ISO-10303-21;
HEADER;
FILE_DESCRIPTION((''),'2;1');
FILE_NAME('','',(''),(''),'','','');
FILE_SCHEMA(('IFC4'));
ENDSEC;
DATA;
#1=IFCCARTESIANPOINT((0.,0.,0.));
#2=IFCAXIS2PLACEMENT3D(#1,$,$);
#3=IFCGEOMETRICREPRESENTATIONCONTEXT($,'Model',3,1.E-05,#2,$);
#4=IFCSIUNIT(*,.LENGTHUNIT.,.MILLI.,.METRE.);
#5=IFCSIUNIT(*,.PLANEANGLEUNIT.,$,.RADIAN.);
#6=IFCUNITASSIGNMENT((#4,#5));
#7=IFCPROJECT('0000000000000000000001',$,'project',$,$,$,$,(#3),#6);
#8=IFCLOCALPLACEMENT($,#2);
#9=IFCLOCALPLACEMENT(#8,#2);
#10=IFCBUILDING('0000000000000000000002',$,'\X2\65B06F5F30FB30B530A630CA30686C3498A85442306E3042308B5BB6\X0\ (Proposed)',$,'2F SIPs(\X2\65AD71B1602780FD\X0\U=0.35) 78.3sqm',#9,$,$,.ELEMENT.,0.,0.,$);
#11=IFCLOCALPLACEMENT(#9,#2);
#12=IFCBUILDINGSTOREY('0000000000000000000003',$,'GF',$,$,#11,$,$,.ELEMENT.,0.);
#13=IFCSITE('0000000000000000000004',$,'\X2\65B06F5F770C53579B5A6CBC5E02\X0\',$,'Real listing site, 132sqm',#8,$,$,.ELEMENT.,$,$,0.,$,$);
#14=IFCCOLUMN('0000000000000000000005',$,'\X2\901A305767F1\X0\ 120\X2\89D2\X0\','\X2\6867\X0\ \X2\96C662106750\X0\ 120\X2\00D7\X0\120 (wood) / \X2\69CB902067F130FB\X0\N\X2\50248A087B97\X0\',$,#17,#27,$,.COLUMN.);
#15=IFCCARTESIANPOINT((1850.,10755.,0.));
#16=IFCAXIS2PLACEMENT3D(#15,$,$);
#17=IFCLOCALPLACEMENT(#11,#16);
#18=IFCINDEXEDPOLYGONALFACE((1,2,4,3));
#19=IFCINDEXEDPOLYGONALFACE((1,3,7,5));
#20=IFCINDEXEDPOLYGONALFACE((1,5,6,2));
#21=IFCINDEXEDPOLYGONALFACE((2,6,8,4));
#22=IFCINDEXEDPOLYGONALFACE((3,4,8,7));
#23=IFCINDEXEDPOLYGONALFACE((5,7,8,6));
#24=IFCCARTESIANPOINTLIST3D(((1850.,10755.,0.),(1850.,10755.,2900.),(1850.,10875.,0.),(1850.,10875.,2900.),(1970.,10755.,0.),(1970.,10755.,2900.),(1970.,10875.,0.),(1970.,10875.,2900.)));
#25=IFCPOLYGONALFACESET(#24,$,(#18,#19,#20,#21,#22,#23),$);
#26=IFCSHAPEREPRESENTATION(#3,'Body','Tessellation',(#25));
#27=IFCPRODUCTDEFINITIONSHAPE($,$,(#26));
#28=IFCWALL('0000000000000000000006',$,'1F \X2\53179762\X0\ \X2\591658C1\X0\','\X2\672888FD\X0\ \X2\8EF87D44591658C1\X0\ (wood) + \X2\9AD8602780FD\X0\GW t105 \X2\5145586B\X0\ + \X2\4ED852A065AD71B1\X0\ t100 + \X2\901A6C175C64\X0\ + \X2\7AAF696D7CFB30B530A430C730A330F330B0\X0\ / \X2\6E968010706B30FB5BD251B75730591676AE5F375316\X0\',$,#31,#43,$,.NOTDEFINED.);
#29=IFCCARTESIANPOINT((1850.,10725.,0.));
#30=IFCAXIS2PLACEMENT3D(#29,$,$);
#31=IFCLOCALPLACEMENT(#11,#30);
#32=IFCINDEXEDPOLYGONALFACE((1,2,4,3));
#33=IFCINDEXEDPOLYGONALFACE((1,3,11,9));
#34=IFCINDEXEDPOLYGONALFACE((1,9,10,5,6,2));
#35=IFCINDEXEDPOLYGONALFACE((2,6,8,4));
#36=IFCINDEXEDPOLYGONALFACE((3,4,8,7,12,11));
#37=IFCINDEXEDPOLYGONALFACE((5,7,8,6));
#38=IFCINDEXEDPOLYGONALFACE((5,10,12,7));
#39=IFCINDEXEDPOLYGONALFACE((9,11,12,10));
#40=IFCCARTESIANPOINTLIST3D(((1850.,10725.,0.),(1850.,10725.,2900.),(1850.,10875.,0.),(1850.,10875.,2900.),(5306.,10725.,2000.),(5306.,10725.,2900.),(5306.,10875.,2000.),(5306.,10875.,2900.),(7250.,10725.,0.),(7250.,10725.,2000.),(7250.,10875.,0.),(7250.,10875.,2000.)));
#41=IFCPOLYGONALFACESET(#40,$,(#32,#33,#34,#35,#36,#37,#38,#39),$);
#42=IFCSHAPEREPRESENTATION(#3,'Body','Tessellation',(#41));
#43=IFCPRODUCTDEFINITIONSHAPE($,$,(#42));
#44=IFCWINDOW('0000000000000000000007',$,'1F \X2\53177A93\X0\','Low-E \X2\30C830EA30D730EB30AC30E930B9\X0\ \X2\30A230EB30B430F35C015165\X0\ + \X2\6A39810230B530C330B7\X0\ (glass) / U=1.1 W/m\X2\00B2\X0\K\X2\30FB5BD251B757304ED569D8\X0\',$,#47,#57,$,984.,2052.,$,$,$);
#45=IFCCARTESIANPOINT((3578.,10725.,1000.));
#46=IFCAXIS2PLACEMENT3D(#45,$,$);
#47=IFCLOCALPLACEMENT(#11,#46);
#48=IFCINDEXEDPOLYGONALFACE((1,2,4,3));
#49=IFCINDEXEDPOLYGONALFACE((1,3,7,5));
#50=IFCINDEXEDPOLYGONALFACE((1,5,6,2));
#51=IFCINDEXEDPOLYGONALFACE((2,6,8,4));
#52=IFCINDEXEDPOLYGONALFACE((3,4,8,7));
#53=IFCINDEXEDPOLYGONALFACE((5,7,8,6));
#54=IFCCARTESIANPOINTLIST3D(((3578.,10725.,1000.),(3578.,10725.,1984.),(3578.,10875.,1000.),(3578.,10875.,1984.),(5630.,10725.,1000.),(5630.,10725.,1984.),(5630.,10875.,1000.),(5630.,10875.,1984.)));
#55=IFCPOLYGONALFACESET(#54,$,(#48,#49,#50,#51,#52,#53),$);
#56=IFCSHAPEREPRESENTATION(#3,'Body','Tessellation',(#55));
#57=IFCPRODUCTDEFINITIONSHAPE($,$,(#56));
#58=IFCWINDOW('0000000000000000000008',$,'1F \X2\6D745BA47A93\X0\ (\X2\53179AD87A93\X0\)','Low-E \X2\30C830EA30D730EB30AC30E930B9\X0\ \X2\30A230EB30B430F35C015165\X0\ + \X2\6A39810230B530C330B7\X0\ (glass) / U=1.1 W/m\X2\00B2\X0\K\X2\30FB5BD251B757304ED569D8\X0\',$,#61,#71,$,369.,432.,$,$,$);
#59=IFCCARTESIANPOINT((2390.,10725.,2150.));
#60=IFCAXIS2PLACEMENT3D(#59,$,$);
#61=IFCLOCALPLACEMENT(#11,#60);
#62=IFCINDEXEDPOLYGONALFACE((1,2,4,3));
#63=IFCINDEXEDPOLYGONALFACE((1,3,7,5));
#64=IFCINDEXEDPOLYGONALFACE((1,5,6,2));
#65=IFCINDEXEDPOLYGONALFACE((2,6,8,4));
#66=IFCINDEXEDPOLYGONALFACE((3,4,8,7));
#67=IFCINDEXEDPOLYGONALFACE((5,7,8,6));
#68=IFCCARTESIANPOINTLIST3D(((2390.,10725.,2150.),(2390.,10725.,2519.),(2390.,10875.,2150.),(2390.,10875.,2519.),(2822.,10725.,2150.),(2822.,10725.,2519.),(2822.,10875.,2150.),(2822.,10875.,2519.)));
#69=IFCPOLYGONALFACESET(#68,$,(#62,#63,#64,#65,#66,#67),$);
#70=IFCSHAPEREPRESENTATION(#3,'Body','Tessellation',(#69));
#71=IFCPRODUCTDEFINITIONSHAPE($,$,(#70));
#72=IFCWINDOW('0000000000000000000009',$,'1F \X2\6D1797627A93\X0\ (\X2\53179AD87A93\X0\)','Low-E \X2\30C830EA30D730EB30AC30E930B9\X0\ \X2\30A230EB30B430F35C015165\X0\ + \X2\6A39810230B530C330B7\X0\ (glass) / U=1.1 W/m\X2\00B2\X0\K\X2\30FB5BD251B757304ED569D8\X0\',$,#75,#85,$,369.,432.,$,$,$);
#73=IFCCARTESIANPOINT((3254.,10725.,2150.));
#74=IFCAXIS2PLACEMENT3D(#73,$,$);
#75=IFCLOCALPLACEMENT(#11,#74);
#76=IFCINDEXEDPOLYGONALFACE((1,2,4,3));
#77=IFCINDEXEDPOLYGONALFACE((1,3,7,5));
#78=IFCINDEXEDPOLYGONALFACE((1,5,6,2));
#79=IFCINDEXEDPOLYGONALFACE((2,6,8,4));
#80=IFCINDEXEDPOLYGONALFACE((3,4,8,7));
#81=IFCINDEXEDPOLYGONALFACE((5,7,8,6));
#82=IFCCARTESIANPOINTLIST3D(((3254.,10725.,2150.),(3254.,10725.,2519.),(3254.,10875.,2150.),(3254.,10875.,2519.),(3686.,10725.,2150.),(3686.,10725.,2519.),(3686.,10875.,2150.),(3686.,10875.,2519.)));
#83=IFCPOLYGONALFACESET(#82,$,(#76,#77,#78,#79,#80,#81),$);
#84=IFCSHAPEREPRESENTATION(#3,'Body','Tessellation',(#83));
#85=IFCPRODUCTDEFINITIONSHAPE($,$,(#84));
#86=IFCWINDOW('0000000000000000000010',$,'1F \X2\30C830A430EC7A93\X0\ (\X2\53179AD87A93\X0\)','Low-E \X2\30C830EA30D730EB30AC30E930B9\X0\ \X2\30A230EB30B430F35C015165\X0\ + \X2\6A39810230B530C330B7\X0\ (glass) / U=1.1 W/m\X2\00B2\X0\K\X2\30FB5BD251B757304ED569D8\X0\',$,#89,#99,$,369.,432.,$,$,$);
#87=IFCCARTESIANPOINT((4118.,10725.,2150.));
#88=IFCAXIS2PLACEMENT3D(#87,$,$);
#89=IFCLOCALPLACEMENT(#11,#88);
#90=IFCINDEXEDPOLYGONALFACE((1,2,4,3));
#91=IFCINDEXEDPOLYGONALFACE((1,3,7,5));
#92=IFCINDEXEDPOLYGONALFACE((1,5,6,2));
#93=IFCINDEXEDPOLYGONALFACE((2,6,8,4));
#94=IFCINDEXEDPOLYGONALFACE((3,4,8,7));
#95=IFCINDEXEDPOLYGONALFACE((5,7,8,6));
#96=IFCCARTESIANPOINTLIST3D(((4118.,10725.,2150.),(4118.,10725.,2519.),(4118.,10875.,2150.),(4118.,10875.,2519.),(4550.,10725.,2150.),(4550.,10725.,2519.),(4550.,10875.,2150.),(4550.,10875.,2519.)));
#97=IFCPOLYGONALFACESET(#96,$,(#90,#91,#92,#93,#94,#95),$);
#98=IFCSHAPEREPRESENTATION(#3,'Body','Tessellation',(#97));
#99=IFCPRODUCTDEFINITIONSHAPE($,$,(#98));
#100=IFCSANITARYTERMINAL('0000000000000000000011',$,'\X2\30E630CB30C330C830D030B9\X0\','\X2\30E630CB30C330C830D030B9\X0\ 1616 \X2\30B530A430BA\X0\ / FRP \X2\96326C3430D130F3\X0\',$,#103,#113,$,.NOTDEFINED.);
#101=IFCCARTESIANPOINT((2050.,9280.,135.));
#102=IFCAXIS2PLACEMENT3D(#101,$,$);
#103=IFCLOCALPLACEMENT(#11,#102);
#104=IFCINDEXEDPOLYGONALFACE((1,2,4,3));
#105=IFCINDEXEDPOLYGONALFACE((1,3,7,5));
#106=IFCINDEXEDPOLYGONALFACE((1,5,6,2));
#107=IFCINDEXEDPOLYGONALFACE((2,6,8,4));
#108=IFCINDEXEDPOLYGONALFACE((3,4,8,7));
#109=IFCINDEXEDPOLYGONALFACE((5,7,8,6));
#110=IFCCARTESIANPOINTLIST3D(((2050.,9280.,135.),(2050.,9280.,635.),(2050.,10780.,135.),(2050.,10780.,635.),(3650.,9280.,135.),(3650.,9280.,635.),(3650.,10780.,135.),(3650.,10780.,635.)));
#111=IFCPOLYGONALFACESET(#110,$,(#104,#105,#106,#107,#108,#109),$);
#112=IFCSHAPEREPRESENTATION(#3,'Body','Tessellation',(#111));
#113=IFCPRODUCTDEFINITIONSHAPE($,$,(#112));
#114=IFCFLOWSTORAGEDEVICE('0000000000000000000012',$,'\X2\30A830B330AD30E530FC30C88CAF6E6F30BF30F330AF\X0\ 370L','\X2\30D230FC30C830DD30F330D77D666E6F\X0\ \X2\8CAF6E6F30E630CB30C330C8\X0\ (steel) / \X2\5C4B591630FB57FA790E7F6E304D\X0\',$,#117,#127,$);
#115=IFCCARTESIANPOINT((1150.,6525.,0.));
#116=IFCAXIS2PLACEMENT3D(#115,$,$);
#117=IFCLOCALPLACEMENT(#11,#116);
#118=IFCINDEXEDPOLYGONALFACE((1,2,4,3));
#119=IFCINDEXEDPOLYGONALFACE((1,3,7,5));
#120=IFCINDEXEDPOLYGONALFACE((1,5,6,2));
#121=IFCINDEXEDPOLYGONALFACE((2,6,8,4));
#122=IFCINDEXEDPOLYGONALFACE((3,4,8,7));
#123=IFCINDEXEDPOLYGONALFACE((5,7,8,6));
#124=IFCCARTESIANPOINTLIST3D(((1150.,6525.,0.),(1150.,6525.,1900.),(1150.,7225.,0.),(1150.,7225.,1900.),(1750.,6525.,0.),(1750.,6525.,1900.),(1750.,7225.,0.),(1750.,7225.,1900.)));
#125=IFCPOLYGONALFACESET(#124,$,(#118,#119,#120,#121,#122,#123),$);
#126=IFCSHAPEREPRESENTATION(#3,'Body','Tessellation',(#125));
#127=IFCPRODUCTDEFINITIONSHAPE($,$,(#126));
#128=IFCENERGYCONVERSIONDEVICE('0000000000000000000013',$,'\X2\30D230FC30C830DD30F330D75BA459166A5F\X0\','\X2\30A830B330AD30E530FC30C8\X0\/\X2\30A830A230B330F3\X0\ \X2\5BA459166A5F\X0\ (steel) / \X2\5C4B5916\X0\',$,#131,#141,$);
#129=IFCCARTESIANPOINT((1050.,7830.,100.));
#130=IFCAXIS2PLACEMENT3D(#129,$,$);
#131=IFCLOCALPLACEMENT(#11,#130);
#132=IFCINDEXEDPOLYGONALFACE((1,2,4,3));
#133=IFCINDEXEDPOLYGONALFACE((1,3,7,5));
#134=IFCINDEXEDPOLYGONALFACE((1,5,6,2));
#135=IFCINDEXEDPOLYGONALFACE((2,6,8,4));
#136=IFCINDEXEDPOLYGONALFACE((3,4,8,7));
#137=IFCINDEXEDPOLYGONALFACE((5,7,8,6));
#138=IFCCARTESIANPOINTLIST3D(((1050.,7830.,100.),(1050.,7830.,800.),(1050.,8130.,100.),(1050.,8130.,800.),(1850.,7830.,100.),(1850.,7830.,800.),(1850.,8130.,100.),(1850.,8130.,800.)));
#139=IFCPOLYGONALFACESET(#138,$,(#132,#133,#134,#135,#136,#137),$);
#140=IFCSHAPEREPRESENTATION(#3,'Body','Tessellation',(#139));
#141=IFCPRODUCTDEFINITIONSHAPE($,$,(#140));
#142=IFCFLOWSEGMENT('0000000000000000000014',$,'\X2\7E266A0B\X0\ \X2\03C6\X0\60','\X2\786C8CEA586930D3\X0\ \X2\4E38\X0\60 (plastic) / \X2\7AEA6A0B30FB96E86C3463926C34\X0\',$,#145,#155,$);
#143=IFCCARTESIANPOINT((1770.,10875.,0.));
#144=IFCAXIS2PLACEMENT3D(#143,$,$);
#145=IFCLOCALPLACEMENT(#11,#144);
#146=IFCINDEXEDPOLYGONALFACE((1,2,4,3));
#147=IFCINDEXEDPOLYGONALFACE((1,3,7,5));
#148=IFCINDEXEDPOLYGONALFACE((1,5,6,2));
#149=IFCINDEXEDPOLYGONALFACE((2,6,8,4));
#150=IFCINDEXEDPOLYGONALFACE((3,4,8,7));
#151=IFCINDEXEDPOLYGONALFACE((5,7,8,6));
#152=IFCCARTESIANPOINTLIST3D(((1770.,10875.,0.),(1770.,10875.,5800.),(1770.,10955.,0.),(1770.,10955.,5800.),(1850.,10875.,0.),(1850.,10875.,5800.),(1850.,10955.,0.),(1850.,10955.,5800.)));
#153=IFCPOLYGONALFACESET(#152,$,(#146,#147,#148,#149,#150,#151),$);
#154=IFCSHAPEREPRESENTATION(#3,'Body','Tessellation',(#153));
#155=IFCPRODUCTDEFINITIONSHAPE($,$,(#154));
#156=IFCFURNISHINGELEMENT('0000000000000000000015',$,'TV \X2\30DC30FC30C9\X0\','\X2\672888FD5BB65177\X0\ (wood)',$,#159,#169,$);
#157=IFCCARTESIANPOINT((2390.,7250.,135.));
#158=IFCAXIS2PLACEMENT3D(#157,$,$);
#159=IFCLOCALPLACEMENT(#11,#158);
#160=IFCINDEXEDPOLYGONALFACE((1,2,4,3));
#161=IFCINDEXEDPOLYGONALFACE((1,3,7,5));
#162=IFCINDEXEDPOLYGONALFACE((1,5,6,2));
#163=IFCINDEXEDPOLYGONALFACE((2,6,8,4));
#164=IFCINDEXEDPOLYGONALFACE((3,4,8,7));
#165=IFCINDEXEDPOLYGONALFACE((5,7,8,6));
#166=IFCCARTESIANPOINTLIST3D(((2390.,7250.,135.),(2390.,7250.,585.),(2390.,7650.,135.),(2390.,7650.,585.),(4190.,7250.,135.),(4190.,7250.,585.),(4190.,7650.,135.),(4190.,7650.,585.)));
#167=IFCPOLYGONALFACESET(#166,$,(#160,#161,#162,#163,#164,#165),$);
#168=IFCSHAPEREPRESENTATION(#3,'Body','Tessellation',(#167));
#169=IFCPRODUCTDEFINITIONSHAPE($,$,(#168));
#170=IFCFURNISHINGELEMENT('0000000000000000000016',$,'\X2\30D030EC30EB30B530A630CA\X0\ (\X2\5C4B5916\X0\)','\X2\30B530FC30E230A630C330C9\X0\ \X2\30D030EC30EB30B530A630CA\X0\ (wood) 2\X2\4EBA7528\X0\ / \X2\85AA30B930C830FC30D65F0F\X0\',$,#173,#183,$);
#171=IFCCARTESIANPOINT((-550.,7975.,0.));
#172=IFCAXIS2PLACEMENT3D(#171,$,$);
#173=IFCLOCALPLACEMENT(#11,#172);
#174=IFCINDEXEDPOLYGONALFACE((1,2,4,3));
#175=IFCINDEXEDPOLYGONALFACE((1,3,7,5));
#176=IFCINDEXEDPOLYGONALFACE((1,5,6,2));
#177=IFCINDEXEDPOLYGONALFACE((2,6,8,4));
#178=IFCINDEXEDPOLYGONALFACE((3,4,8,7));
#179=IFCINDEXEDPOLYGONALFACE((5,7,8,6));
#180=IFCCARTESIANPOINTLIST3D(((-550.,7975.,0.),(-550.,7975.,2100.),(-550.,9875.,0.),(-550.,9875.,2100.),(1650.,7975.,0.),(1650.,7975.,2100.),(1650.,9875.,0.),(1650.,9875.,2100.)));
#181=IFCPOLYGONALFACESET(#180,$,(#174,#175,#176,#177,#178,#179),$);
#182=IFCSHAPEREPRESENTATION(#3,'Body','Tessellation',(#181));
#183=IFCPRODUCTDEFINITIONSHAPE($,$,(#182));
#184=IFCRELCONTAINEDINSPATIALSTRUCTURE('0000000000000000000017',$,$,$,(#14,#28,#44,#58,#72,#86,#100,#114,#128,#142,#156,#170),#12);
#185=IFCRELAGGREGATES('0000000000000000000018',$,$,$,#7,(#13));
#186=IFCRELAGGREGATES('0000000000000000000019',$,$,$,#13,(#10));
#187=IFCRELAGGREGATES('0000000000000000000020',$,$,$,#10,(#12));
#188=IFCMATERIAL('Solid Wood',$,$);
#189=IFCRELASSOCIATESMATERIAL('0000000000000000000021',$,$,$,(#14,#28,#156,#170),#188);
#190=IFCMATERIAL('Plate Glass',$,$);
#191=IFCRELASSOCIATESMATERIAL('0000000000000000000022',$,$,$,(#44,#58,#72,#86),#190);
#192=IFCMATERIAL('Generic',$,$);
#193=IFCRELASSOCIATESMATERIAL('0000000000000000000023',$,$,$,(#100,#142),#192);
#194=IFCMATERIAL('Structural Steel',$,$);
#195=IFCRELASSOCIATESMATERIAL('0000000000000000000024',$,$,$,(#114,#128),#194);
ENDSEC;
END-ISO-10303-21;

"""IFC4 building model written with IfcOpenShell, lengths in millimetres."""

from ifc_helpers import new_model, si_unit, frame, frame_2d, origin, place, context, project, spatial, rectangle, extrude, material, element, fill, save


model = new_model("IFC4")

# Units and contexts
model_context = context("Model", 3, precision=1e-05, world=origin())
ifc_project = project(units=[si_unit("LENGTHUNIT", "METRE", prefix="MILLI"), si_unit("PLANEANGLEUNIT", "RADIAN")], contexts=[model_context])

# Site, building, storey
site_placement = place(None, origin())
site = spatial("IfcSite", under=ifc_project, at=site_placement, Name="新潟県南魚沼市", ObjectType="Real listing site, 132sqm", CompositionType="ELEMENT", RefElevation=0.0)
building_placement = place(site_placement, origin())
building = spatial("IfcBuilding", under=site, at=building_placement, Name="新潟・サウナと水風呂のある家 (Proposed)", ObjectType="2F SIPs(断熱性能U=0.35) 78.3sqm", CompositionType="ELEMENT", ElevationOfRefHeight=0.0, ElevationOfTerrain=0.0)
storey_placement = place(building_placement, origin())
storey = spatial("IfcBuildingStorey", under=building, at=storey_placement, Name="GF", CompositionType="ELEMENT", Elevation=0.0)

# Column
ifc_material_1 = material(Name="Solid Wood")
column_1_placement = place(storey_placement, frame((1850.0, 10755.0, 0.0)))
element("IfcColumn", 1, at=column_1_placement, inside=storey, material=ifc_material_1, Name="通し柱 120角", Description="桧 集成材 120×120 (wood) / 構造柱・N値計算", PredefinedType="COLUMN", context=model_context, shape_type="SweptSolid", body=[
    extrude(rectangle(XDim=120.0, YDim=120.0, at=frame_2d((60.0, 60.0))), frame((1850.0, 10755.0, 0.0)), (0.0, 0.0, 1.0), 2900.0),
])

# Wall, openings, windows
wall_1_placement = place(storey_placement, frame((1850.0, 10725.0, 0.0)))
wall_1 = element("IfcWall", 2, at=wall_1_placement, inside=storey, material=ifc_material_1, Name="1F 北面 外壁", Description="木製 軸組外壁 (wood) + 高性能GW t105 充填 + 付加断熱 t100 + 通気層 + 窯業系サイディング / 準耐火・寒冷地外皮強化", PredefinedType="NOTDEFINED", context=model_context, shape_type="SweptSolid", body=[
    extrude(rectangle(XDim=5400.0, YDim=150.0, at=frame_2d((2700.0, 75.0))), frame((1850.0, 10725.0, 0.0)), (0.0, 0.0, 1.0), 2900.0),
])
opening_1_placement = place(storey_placement, frame((3578.0, 10725.0, 1000.0)))
opening_1 = element("IfcOpeningElement", 3, at=opening_1_placement, cuts=wall_1, PredefinedType="NOTDEFINED", context=model_context, shape_type="SweptSolid", body=[
    extrude(rectangle(XDim=2052.0, YDim=150.0, at=frame_2d((1026.0, 75.0))), frame((3578.0, 10725.0, 1000.0)), (0.0, 0.0, 1.0), 984.0),
])
opening_2_placement = place(storey_placement, frame((2390.0, 10725.0, 2150.0)))
opening_2 = element("IfcOpeningElement", 4, at=opening_2_placement, cuts=wall_1, PredefinedType="NOTDEFINED", context=model_context, shape_type="SweptSolid", body=[
    extrude(rectangle(XDim=432.0, YDim=150.0, at=frame_2d((216.0, 75.0))), frame((2390.0, 10725.0, 2150.0)), (0.0, 0.0, 1.0), 369.0),
])
opening_3_placement = place(storey_placement, frame((3254.0, 10725.0, 2150.0)))
opening_3 = element("IfcOpeningElement", 5, at=opening_3_placement, cuts=wall_1, PredefinedType="NOTDEFINED", context=model_context, shape_type="SweptSolid", body=[
    extrude(rectangle(XDim=432.0, YDim=150.0, at=frame_2d((216.0, 75.0))), frame((3254.0, 10725.0, 2150.0)), (0.0, 0.0, 1.0), 369.0),
])
opening_4_placement = place(storey_placement, frame((4118.0, 10725.0, 2150.0)))
opening_4 = element("IfcOpeningElement", 6, at=opening_4_placement, cuts=wall_1, PredefinedType="NOTDEFINED", context=model_context, shape_type="SweptSolid", body=[
    extrude(rectangle(XDim=432.0, YDim=150.0, at=frame_2d((216.0, 75.0))), frame((4118.0, 10725.0, 2150.0)), (0.0, 0.0, 1.0), 369.0),
])
ifc_material_2 = material(Name="Plate Glass")
window_1_placement = place(storey_placement, frame((3578.0, 10725.0, 1000.0)))
window_1 = element("IfcWindow", 7, at=window_1_placement, inside=storey, material=ifc_material_2, Name="1F 北窓", Description="Low-E トリプルガラス アルゴン封入 + 樹脂サッシ (glass) / U=1.1 W/m²K・寒冷地仕様", OverallHeight=984.0, OverallWidth=2052.0, context=model_context, shape_type="SweptSolid", body=[
    extrude(rectangle(XDim=2052.0, YDim=150.0, at=frame_2d((1026.0, 75.0))), frame((3578.0, 10725.0, 1000.0)), (0.0, 0.0, 1.0), 984.0),
])
fill(opening_1, window_1)
window_2_placement = place(storey_placement, frame((2390.0, 10725.0, 2150.0)))
window_2 = element("IfcWindow", 8, at=window_2_placement, inside=storey, material=ifc_material_2, Name="1F 浴室窓 (北高窓)", Description="Low-E トリプルガラス アルゴン封入 + 樹脂サッシ (glass) / U=1.1 W/m²K・寒冷地仕様", OverallHeight=369.0, OverallWidth=432.0, context=model_context, shape_type="SweptSolid", body=[
    extrude(rectangle(XDim=432.0, YDim=150.0, at=frame_2d((216.0, 75.0))), frame((2390.0, 10725.0, 2150.0)), (0.0, 0.0, 1.0), 369.0),
])
fill(opening_2, window_2)
window_3_placement = place(storey_placement, frame((3254.0, 10725.0, 2150.0)))
window_3 = element("IfcWindow", 9, at=window_3_placement, inside=storey, material=ifc_material_2, Name="1F 洗面窓 (北高窓)", Description="Low-E トリプルガラス アルゴン封入 + 樹脂サッシ (glass) / U=1.1 W/m²K・寒冷地仕様", OverallHeight=369.0, OverallWidth=432.0, context=model_context, shape_type="SweptSolid", body=[
    extrude(rectangle(XDim=432.0, YDim=150.0, at=frame_2d((216.0, 75.0))), frame((3254.0, 10725.0, 2150.0)), (0.0, 0.0, 1.0), 369.0),
])
fill(opening_3, window_3)
window_4_placement = place(storey_placement, frame((4118.0, 10725.0, 2150.0)))
window_4 = element("IfcWindow", 10, at=window_4_placement, inside=storey, material=ifc_material_2, Name="1F トイレ窓 (北高窓)", Description="Low-E トリプルガラス アルゴン封入 + 樹脂サッシ (glass) / U=1.1 W/m²K・寒冷地仕様", OverallHeight=369.0, OverallWidth=432.0, context=model_context, shape_type="SweptSolid", body=[
    extrude(rectangle(XDim=432.0, YDim=150.0, at=frame_2d((216.0, 75.0))), frame((4118.0, 10725.0, 2150.0)), (0.0, 0.0, 1.0), 369.0),
])
fill(opening_4, window_4)

# Sanitary terminal
ifc_material_3 = material(Name="Generic")
sanitary_terminal_placement = place(storey_placement, frame((2050.0, 9280.0, 135.0)))
element("IfcSanitaryTerminal", 11, at=sanitary_terminal_placement, inside=storey, material=ifc_material_3, Name="ユニットバス", Description="ユニットバス 1616 サイズ / FRP 防水パン", PredefinedType="NOTDEFINED", context=model_context, shape_type="SweptSolid", body=[
    extrude(rectangle(XDim=1600.0, YDim=1500.0, at=frame_2d((800.0, 750.0))), frame((2050.0, 9280.0, 135.0)), (0.0, 0.0, 1.0), 500.0),
])

# Flow storage device
ifc_material_4 = material(Name="Structural Steel")
flow_storage_device_placement = place(storey_placement, frame((1150.0, 6525.0, 0.0)))
element("IfcFlowStorageDevice", 12, at=flow_storage_device_placement, inside=storey, material=ifc_material_4, Name="エコキュート貯湯タンク 370L", Description="ヒートポンプ給湯 貯湯ユニット (steel) / 屋外・基礎置き", context=model_context, shape_type="SweptSolid", body=[
    extrude(rectangle(XDim=600.0, YDim=700.0, at=frame_2d((300.0, 350.0))), frame((1150.0, 6525.0, 0.0)), (0.0, 0.0, 1.0), 1900.0),
])

# Energy conversion device
energy_conversion_device_placement = place(storey_placement, frame((1050.0, 7830.0, 100.0)))
element("IfcEnergyConversionDevice", 13, at=energy_conversion_device_placement, inside=storey, material=ifc_material_4, Name="ヒートポンプ室外機", Description="エコキュート/エアコン 室外機 (steel) / 屋外", context=model_context, shape_type="SweptSolid", body=[
    extrude(rectangle(XDim=800.0, YDim=300.0, at=frame_2d((400.0, 150.0))), frame((1050.0, 7830.0, 100.0)), (0.0, 0.0, 1.0), 700.0),
])

# Flow segment
flow_segment_placement = place(storey_placement, frame((1770.0, 10875.0, 0.0)))
element("IfcFlowSegment", 14, at=flow_segment_placement, inside=storey, material=ifc_material_3, Name="縦樋 φ60", Description="硬質塩ビ 丸60 (plastic) / 竪樋・雨水排水", context=model_context, shape_type="SweptSolid", body=[
    extrude(rectangle(XDim=80.0, YDim=80.0, at=frame_2d((40.0, 40.0))), frame((1770.0, 10875.0, 0.0)), (0.0, 0.0, 1.0), 5800.0),
])

# Furnishing elements
furnishing_1_placement = place(storey_placement, frame((2390.0, 7250.0, 135.0)))
element("IfcFurnishingElement", 15, at=furnishing_1_placement, inside=storey, material=ifc_material_1, Name="TV ボード", Description="木製家具 (wood)", context=model_context, shape_type="SweptSolid", body=[
    extrude(rectangle(XDim=1800.0, YDim=400.0, at=frame_2d((900.0, 200.0))), frame((2390.0, 7250.0, 135.0)), (0.0, 0.0, 1.0), 450.0),
])
furnishing_2_placement = place(storey_placement, frame((-550.0, 7975.0, 0.0)))
element("IfcFurnishingElement", 16, at=furnishing_2_placement, inside=storey, material=ifc_material_1, Name="バレルサウナ (屋外)", Description="サーモウッド バレルサウナ (wood) 2人用 / 薪ストーブ式", context=model_context, shape_type="SweptSolid", body=[
    extrude(rectangle(XDim=2200.0, YDim=1900.0, at=frame_2d((1100.0, 950.0))), frame((-550.0, 7975.0, 0.0)), (0.0, 0.0, 1.0), 2100.0),
])

save(model, "model.ifc")
